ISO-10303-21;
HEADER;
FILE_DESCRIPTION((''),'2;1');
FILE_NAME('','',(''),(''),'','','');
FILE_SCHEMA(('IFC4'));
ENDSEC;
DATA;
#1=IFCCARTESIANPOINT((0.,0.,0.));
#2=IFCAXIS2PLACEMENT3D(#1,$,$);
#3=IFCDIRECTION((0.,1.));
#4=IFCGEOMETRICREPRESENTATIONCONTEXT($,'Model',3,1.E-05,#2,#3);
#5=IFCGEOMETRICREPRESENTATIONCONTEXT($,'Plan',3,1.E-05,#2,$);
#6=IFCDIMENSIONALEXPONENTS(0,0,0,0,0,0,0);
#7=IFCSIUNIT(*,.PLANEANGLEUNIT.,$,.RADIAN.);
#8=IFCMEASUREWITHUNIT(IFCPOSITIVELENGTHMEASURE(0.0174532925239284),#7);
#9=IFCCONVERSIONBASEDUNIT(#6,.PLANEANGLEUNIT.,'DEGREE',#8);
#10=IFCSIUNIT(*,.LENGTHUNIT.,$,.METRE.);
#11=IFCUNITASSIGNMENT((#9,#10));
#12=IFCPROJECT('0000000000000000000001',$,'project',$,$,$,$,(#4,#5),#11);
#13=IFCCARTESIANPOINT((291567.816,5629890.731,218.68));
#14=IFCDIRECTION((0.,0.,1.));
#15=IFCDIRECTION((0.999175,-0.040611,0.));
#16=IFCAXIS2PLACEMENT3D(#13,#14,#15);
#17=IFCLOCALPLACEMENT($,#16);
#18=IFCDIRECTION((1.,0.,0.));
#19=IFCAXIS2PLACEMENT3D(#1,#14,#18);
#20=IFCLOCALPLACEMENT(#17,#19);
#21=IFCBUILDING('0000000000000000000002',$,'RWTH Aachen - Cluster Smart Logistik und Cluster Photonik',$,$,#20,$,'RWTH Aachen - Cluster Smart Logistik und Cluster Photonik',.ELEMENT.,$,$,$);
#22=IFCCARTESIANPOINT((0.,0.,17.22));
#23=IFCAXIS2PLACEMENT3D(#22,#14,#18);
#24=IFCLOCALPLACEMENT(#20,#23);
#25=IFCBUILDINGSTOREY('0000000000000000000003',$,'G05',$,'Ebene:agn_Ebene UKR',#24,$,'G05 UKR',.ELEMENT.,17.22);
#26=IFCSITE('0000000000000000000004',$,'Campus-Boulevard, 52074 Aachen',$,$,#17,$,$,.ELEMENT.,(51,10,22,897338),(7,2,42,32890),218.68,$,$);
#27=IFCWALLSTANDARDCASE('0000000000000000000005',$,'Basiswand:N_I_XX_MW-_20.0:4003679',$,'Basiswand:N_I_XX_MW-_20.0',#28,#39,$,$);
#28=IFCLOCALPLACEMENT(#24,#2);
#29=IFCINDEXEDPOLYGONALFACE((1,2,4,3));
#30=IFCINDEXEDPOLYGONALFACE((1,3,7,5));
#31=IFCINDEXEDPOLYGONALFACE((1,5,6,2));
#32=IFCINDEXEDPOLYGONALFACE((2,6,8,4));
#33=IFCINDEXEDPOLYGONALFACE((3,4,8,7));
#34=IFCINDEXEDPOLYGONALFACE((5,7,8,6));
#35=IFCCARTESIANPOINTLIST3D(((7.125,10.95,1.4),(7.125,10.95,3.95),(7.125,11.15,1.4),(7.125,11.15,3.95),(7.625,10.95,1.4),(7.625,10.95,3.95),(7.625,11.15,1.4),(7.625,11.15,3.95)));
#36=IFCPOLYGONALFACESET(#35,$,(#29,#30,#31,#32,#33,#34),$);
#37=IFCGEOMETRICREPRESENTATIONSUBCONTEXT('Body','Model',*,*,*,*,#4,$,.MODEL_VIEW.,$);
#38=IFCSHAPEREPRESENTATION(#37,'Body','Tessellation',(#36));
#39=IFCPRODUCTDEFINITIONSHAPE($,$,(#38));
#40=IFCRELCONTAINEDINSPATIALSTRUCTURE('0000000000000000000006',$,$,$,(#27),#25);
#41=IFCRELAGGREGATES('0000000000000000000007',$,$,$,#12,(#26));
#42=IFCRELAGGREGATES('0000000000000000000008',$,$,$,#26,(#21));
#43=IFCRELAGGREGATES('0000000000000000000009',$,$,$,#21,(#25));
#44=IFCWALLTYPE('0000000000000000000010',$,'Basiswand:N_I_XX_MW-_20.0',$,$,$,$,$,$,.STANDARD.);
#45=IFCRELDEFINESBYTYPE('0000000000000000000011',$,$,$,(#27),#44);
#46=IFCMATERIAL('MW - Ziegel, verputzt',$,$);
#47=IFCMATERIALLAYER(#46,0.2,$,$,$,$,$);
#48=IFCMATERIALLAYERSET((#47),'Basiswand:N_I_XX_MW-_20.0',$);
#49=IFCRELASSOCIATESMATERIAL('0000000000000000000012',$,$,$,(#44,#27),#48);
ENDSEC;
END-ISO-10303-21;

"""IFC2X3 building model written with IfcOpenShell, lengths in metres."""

from ifc_helpers import new_model, entity, si_unit, converted_unit, direction, frame, frame_2d, origin, origin_with_axes, place, context, subcontext, project, spatial, rectangle, extrude, material, layer, layer_set, layer_usage, type_object, element, save


model = new_model("IFC2X3")

# Units and contexts
model_context = context("Model", 3, precision=1e-05, world=origin(), true_north=direction((0.0, 1.0)))
plan_context = context("Plan", 3, precision=1e-05, world=origin())
body_context = subcontext(model_context, "Body", "Model", "MODEL_VIEW")
ifc_project = project(units=[converted_unit("PLANEANGLEUNIT", "DEGREE", entity("IfcPositiveLengthMeasure", 0.0174532925239284), si_unit("PLANEANGLEUNIT", "RADIAN"), dimensions=[0, 0, 0, 0, 0, 0, 0]), si_unit("LENGTHUNIT", "METRE")], contexts=[model_context, plan_context])

# Site, building, storey
site_placement = place(None, frame((291567.816, 5629890.731, 218.68), z_axis=(0.0, 0.0, 1.0), x_axis=(0.999175, -0.040611, 0.0)))
site = spatial("IfcSite", under=ifc_project, at=site_placement, Name="Campus-Boulevard, 52074 Aachen", CompositionType="ELEMENT", RefLatitude=(51, 10, 22, 897338), RefLongitude=(7, 2, 42, 32890), RefElevation=218.68)
building_placement = place(site_placement, origin_with_axes())
building = spatial("IfcBuilding", under=site, at=building_placement, Name="RWTH Aachen - Cluster Smart Logistik und Cluster Photonik", LongName="RWTH Aachen - Cluster Smart Logistik und Cluster Photonik", CompositionType="ELEMENT")
storey_placement = place(building_placement, frame((0.0, 0.0, 17.22), z_axis=(0.0, 0.0, 1.0), x_axis=(1.0, 0.0, 0.0)))
storey = spatial("IfcBuildingStorey", under=building, at=storey_placement, Name="G05", ObjectType="Ebene:agn_Ebene UKR", LongName="G05 UKR", CompositionType="ELEMENT", Elevation=17.22)

# Wall
ifc_material_1 = material(Name="MW - Ziegel, verputzt")
ifc_layer_1 = layer(ifc_material_1, 0.2)
ifc_layer_set_1 = layer_set([ifc_layer_1], Name="Basiswand:N_I_XX_MW-_20.0")
wall_type_1 = type_object("IfcWallType", Name="Basiswand:N_I_XX_MW-_20.0", PredefinedType="STANDARD", material=ifc_layer_set_1)
ifc_layer_usage_1 = layer_usage(ifc_layer_set_1, "AXIS2", "NEGATIVE", 0.1)
wall_1_placement = place(storey_placement, frame((7.625, 11.05, 1.4), z_axis=(0.0, 0.0, 1.0), x_axis=(-1.0, 0.0, 0.0)))
element("IfcWallStandardCase", 1, at=wall_1_placement, inside=storey, type_object=wall_type_1, material=ifc_layer_usage_1, Name="Basiswand:N_I_XX_MW-_20.0:4003679", ObjectType="Basiswand:N_I_XX_MW-_20.0", context=body_context, shape_type="SweptSolid", body=[
    extrude(rectangle(XDim=0.5, YDim=0.2, at=frame_2d((0.25, 0.0), x_axis=(-1.0, 0.0))), origin(), (0.0, 0.0, 1.0), 2.55),
])

save(model, "model.ifc")
